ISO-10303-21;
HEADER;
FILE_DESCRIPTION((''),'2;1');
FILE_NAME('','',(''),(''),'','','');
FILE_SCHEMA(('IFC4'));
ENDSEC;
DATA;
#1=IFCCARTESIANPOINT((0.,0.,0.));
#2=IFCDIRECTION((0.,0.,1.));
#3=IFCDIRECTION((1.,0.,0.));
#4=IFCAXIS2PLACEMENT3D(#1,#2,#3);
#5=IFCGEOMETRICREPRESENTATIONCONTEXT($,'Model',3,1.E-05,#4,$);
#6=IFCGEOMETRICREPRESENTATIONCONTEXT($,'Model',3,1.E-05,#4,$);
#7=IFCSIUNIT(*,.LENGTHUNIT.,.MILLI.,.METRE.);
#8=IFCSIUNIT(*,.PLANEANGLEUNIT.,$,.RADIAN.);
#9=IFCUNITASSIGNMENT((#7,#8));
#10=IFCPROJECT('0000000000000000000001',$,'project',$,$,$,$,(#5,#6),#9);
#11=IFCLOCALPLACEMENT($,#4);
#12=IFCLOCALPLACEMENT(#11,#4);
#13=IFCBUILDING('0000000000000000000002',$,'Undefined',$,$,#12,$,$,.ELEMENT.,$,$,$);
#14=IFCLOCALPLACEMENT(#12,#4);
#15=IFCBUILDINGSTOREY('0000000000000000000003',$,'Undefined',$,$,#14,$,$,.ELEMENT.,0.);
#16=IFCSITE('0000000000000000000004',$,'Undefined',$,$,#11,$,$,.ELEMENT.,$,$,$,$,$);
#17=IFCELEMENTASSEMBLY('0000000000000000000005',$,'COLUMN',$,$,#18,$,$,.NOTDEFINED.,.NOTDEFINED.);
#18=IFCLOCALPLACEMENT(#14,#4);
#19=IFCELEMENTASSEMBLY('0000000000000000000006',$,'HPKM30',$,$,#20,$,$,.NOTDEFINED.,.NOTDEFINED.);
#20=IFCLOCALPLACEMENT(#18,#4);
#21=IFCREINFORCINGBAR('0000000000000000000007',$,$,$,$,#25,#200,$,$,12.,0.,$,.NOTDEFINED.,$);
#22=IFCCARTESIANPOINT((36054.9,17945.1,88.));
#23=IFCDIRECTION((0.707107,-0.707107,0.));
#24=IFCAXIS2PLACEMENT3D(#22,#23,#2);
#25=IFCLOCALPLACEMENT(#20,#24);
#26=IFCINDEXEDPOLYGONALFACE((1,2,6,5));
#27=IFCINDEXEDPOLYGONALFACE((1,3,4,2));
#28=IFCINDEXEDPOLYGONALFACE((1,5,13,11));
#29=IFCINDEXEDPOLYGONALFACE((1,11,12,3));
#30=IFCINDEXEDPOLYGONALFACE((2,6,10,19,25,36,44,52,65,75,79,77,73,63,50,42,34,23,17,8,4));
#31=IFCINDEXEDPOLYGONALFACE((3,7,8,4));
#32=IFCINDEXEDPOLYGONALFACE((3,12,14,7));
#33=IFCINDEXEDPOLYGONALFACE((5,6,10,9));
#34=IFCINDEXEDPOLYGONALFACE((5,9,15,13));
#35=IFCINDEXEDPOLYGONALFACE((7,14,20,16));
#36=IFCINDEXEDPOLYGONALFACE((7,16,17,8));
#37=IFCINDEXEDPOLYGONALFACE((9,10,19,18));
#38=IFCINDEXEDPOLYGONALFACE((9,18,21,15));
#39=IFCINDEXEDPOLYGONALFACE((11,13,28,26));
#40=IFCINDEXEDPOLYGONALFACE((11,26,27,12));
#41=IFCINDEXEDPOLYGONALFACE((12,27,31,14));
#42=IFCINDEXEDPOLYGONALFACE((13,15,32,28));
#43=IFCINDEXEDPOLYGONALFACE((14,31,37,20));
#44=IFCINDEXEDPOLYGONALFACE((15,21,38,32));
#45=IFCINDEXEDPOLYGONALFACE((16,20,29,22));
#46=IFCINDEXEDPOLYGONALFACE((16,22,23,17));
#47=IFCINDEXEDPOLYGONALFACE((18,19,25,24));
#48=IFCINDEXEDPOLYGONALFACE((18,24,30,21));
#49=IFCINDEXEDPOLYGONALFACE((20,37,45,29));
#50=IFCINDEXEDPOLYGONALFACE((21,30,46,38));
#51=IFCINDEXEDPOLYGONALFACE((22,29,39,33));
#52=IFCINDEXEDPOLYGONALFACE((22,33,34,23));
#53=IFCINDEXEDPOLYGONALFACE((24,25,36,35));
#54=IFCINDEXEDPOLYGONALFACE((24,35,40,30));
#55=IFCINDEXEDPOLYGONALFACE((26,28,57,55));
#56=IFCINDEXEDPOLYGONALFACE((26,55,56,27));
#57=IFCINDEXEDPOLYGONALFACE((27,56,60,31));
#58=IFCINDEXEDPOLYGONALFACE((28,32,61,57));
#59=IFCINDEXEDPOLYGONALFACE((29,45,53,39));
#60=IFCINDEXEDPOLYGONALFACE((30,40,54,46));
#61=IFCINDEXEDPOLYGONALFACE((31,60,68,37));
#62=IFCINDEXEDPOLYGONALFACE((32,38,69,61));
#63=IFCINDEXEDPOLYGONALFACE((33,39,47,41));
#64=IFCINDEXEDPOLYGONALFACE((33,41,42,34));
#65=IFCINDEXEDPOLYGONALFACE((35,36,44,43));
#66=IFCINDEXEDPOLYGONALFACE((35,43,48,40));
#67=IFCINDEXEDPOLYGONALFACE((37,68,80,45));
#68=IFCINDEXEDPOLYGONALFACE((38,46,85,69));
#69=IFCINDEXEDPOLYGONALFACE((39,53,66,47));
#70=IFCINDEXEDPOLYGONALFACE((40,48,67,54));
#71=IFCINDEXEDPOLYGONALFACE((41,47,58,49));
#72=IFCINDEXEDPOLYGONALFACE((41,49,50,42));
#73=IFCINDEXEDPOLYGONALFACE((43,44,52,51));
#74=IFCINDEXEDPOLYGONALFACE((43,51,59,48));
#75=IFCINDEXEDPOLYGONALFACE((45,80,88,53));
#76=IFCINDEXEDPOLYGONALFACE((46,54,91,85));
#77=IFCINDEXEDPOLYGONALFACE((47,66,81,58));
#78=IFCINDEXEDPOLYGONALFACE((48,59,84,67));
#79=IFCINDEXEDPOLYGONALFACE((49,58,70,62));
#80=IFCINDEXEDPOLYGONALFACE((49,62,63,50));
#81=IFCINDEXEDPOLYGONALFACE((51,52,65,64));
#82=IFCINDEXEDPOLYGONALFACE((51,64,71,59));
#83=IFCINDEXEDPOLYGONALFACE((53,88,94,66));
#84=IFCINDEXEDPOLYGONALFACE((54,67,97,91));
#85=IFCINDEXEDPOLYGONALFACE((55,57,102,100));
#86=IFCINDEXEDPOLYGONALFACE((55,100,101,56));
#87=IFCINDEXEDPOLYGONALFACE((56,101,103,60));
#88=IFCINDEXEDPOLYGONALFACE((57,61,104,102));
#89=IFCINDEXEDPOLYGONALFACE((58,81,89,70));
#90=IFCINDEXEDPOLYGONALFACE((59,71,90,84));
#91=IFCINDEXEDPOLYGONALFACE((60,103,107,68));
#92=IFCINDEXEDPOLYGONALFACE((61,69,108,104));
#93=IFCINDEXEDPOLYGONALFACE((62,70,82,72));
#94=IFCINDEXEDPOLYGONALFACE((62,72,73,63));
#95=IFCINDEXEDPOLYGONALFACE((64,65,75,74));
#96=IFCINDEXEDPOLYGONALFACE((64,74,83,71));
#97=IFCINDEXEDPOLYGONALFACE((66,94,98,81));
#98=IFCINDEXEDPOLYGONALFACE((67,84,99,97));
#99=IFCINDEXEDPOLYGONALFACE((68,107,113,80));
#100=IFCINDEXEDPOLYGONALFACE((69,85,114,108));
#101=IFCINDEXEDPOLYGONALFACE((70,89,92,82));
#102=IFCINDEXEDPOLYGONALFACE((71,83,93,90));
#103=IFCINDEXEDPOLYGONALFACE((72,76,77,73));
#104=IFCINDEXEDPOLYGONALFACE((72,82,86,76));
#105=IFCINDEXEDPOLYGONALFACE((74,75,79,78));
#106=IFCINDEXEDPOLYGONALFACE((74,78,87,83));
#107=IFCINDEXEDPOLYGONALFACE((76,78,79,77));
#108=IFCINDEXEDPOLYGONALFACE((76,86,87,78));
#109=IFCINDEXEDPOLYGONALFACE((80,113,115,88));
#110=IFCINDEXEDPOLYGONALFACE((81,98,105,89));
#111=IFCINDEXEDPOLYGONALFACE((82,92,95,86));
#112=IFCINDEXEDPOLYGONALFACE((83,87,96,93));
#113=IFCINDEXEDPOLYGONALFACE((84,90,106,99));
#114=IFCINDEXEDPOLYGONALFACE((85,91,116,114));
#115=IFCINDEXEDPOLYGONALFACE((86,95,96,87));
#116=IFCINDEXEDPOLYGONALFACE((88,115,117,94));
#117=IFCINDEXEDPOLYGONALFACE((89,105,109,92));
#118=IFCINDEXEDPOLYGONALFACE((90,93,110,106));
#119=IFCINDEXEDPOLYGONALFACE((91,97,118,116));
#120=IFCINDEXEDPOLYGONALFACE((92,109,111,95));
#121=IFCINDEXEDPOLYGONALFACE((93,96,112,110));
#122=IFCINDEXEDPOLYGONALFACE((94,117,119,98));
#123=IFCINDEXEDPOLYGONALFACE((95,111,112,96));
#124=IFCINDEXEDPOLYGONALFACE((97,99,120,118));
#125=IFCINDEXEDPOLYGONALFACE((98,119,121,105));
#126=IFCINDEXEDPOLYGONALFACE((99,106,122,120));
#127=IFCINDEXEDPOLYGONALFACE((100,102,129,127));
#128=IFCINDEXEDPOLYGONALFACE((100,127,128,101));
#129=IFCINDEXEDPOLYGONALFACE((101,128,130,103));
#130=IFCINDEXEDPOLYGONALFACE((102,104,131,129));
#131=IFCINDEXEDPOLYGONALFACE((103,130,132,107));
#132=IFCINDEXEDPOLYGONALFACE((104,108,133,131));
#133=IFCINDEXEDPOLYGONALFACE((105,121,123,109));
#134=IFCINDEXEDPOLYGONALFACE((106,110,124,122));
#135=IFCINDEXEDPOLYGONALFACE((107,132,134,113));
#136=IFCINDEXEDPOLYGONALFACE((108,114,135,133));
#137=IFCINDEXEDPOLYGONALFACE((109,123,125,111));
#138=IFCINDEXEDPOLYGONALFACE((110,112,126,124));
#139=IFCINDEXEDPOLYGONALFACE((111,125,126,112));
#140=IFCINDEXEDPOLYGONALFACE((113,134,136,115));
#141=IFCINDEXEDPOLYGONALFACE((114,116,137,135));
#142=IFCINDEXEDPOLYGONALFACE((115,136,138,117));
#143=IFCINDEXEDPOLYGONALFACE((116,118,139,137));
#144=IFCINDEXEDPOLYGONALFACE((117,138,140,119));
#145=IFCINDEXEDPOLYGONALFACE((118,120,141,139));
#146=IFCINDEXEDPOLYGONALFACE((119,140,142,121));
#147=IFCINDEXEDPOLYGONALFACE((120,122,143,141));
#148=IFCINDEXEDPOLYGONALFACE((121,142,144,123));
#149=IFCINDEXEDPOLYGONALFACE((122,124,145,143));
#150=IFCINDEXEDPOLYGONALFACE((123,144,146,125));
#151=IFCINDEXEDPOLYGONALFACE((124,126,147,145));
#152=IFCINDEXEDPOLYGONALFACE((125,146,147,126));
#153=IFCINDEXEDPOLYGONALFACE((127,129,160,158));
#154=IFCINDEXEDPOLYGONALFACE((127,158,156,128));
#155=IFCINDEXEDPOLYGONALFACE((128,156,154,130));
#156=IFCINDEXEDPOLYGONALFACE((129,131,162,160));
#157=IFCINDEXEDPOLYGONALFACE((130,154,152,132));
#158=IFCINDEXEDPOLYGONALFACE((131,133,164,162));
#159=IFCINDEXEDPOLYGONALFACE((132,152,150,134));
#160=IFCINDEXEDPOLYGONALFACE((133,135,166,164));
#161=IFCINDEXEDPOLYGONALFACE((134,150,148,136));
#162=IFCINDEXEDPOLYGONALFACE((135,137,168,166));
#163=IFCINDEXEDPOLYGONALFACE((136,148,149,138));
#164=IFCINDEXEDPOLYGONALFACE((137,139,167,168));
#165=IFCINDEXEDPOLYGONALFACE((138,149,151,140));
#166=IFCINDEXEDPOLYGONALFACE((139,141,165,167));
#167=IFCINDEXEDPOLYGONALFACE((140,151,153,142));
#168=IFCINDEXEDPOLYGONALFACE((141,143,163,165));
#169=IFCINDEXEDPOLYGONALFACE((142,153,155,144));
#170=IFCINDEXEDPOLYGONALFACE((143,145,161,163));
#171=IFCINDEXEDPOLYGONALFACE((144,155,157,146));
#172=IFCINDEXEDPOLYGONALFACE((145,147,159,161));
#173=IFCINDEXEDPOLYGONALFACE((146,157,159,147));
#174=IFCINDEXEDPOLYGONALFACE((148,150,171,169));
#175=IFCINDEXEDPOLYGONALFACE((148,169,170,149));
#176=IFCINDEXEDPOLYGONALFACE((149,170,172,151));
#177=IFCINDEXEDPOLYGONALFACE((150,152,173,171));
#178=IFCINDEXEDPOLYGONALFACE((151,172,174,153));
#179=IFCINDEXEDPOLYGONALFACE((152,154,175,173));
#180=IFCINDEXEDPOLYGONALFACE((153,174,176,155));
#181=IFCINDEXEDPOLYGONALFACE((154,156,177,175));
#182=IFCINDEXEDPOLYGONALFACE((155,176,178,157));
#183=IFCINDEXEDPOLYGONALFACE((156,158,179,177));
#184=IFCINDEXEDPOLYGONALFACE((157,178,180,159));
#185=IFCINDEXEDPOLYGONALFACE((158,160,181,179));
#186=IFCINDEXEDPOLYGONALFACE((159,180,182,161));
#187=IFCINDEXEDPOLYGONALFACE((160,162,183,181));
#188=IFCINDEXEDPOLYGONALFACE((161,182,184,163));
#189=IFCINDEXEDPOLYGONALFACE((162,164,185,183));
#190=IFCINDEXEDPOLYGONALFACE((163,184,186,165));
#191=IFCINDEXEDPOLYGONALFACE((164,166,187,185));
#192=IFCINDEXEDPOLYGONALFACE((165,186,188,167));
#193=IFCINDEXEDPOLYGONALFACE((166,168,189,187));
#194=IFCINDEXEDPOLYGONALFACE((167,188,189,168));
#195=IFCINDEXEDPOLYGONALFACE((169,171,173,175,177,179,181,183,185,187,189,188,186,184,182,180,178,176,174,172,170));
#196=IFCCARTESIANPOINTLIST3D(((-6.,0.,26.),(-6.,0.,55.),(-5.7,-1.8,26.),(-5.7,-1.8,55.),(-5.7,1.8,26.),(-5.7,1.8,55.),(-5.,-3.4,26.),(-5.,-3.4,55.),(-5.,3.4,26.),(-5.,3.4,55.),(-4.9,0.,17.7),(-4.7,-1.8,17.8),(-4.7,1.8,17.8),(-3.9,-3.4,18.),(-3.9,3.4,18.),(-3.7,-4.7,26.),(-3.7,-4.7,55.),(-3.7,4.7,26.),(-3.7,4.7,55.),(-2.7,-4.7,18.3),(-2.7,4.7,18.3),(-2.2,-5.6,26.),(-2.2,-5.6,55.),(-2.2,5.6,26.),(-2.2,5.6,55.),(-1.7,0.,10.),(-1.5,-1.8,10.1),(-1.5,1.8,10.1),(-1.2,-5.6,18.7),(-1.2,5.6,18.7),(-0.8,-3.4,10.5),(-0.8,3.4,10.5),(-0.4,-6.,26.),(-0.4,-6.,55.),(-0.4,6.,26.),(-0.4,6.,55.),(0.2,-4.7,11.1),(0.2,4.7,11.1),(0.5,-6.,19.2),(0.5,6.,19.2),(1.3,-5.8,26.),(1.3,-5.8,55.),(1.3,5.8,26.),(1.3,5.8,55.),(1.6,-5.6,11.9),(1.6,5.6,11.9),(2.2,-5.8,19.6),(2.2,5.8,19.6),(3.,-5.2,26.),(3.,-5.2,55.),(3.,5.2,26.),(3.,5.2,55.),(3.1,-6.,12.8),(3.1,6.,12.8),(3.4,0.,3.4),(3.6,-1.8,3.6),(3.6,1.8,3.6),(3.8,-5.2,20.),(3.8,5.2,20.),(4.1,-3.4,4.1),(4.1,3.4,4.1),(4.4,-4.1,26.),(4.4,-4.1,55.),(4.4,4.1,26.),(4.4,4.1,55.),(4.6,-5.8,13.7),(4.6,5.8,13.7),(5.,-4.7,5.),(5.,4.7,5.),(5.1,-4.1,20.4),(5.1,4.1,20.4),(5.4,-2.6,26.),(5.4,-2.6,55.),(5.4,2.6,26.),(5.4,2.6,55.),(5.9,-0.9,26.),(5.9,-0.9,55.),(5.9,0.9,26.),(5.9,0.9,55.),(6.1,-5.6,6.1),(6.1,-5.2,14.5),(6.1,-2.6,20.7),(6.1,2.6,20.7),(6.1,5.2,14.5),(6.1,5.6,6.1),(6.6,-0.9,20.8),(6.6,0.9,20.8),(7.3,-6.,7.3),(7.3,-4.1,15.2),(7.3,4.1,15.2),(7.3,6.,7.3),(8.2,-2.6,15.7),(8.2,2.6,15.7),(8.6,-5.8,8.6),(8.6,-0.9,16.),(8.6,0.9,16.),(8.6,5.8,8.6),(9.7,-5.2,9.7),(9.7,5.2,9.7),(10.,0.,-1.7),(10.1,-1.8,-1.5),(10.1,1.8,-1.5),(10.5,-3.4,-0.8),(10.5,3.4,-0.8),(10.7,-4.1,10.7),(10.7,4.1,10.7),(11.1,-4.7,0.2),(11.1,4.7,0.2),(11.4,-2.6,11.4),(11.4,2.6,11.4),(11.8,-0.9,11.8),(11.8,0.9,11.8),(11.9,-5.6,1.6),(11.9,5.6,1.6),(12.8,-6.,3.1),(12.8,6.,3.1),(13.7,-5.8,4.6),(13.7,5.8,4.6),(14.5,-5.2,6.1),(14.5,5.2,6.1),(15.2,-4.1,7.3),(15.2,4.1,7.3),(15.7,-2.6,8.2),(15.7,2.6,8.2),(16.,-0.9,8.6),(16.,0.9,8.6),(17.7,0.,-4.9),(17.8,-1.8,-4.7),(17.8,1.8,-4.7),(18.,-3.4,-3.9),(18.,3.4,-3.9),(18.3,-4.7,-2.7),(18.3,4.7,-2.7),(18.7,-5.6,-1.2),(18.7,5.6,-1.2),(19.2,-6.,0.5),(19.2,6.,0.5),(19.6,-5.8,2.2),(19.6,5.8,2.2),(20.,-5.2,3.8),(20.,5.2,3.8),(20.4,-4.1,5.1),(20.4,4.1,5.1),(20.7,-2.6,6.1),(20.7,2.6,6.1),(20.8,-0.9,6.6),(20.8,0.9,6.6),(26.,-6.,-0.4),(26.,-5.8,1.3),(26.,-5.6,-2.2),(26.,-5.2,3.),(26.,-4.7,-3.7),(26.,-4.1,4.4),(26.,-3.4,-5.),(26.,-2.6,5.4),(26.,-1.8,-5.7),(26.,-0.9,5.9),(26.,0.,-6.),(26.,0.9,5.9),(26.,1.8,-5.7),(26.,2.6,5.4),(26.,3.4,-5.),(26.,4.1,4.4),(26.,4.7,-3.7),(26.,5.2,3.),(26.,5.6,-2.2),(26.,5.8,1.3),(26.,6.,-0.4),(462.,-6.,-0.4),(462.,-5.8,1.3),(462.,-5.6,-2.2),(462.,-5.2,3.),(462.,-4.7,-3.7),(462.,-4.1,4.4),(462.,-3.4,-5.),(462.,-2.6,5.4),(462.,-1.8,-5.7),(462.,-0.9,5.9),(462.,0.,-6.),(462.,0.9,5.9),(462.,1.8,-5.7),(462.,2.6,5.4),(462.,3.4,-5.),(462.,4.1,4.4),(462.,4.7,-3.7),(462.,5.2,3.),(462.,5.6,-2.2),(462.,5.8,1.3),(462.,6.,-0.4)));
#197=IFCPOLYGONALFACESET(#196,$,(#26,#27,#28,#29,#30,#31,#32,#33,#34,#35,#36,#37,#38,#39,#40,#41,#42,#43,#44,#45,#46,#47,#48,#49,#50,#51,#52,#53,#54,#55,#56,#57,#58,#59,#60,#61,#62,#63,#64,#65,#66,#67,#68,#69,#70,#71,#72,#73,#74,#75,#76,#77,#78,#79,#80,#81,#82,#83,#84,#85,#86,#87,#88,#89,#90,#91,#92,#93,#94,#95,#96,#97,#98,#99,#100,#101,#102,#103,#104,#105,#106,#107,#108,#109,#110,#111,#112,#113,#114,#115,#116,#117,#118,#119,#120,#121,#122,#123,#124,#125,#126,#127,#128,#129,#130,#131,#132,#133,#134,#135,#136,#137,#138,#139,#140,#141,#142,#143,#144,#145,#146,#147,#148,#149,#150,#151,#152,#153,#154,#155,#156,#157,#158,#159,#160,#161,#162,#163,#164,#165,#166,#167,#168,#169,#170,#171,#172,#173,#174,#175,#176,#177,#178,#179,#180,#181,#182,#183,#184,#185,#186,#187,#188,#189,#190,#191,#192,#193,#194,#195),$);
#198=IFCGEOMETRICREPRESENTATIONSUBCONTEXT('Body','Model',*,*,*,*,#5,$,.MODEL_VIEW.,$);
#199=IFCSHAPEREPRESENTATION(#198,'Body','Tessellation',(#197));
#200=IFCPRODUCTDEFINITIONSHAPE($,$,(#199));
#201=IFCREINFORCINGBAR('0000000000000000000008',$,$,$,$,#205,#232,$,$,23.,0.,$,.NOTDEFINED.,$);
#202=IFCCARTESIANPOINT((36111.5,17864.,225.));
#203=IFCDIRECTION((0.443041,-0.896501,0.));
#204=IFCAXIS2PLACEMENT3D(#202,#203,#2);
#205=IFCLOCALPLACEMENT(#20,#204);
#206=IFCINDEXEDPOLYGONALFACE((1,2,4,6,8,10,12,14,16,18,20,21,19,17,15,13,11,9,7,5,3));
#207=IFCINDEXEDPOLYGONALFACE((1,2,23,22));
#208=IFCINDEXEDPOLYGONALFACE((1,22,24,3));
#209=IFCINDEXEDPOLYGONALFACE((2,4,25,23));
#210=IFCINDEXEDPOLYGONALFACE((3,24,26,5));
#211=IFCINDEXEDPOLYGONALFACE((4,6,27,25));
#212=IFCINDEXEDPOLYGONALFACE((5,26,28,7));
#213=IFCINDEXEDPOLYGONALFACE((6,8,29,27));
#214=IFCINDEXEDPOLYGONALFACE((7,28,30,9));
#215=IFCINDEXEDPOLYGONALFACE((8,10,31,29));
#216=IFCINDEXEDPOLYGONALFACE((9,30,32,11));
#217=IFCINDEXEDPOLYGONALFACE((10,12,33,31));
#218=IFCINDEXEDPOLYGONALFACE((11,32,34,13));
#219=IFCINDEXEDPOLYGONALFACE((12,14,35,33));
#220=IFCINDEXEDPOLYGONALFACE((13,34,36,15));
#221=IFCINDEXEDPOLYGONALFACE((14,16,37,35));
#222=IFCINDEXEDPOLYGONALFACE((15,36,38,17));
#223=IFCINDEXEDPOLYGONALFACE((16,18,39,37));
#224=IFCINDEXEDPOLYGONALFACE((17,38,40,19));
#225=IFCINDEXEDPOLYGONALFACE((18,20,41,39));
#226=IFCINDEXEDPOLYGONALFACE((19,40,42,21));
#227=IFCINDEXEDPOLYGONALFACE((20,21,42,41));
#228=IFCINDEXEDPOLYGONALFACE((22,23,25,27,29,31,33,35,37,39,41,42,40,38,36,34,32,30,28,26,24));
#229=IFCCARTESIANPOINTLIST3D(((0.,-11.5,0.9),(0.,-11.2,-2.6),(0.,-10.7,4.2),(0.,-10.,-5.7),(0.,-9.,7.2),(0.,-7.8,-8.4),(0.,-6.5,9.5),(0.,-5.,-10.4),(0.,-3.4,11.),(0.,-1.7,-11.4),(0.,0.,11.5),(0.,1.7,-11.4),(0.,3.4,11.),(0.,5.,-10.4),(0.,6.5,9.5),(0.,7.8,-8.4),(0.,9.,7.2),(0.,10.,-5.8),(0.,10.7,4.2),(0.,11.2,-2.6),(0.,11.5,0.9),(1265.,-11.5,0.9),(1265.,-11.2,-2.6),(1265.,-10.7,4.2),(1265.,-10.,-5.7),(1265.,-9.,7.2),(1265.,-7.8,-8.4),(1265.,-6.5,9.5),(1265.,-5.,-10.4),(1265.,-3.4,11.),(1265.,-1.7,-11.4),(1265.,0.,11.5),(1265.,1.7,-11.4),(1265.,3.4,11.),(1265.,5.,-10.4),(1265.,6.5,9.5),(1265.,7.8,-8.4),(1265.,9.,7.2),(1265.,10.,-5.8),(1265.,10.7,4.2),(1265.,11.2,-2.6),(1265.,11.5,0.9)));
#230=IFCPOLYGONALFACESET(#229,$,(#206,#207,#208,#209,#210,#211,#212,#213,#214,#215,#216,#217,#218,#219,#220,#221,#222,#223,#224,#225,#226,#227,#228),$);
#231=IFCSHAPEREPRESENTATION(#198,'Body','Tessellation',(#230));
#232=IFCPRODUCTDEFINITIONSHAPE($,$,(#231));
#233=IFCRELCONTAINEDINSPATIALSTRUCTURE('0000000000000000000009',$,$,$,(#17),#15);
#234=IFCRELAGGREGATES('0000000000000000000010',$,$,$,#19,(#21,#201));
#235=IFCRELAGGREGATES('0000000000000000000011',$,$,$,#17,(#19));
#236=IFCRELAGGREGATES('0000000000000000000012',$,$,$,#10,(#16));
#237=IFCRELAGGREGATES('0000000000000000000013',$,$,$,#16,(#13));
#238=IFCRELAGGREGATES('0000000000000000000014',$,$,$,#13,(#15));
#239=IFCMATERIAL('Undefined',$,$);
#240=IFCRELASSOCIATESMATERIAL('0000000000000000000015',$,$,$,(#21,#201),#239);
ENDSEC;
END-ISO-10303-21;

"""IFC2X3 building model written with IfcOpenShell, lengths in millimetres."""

from ifc_helpers import new_model, entity, si_unit, frame, origin_with_axes, place, context, subcontext, project, spatial, source, transform, mapped, material, element, aggregate, save


model = new_model("IFC2X3")

# Units and contexts
model_context_1 = context("Model", 3, precision=1e-05, world=origin_with_axes())
model_context_2 = context("Model", 3, precision=1e-05, world=origin_with_axes())
body_context = subcontext(model_context_1, "Body", "Model", "MODEL_VIEW")
ifc_project = project(units=[si_unit("LENGTHUNIT", "METRE", prefix="MILLI"), si_unit("PLANEANGLEUNIT", "RADIAN")], contexts=[model_context_1, model_context_2])

# Site, building, storey
site_placement = place(None, origin_with_axes())
site = spatial("IfcSite", under=ifc_project, at=site_placement, Name="Undefined", CompositionType="ELEMENT")
building_placement = place(site_placement, origin_with_axes())
building = spatial("IfcBuilding", under=site, at=building_placement, Name="Undefined", CompositionType="ELEMENT")
storey_placement = place(building_placement, origin_with_axes())
storey = spatial("IfcBuildingStorey", under=building, at=storey_placement, Name="Undefined", CompositionType="ELEMENT", Elevation=0.0)

# Element assembly
assembly_1_placement = place(storey_placement, origin_with_axes())
assembly_1 = element("IfcElementAssembly", 1, at=assembly_1_placement, inside=storey, Name="COLUMN", AssemblyPlace="NOTDEFINED", PredefinedType="NOTDEFINED")

# Element assembly
assembly_2_placement = place(assembly_1_placement, origin_with_axes())
assembly_2 = element("IfcElementAssembly", 2, at=assembly_2_placement, Name="HPKM30", AssemblyPlace="NOTDEFINED", PredefinedType="NOTDEFINED")

# Shared definitions
ifc_material_1 = material(Name="Undefined")

# Reinforcing bars
shared_shape_1 = source(origin_with_axes(), body_context, "Body", "AdvancedSweptSolid", [
    entity("IfcSweptDiskSolid", entity("IfcCompositeCurve", [entity("IfcCompositeCurveSegment", "CONTINUOUS", True, entity("IfcTrimmedCurve", entity("IfcLine", entity("IfcCartesianPoint", [0.0, 0.0, 0.0]), entity("IfcVector", entity("IfcDirection", [0.0, 0.0, -1.0]), 1.0)), [entity("IfcParameterValue", 0.0)], [entity("IfcParameterValue", 29.0)], True, "PARAMETER")), entity("IfcCompositeCurveSegment", "CONTINUOUS", True, entity("IfcTrimmedCurve", entity("IfcCircle", entity("IfcAxis2Placement3D", entity("IfcCartesianPoint", [26.0, 0.0, -29.0]), entity("IfcDirection", [0.0, -1.0, 0.0]), entity("IfcDirection", [-1.0, 0.0, 0.0])), 26.0), [entity("IfcParameterValue", 0.0)], [entity("IfcParameterValue", 1.570796)], True, "PARAMETER")), entity("IfcCompositeCurveSegment", "DISCONTINUOUS", True, entity("IfcTrimmedCurve", entity("IfcLine", entity("IfcCartesianPoint", [26.0, 0.0, -55.0]), entity("IfcVector", entity("IfcDirection", [1.0, 0.0, 0.0]), 1.0)), [entity("IfcParameterValue", 0.0)], [entity("IfcParameterValue", 436.0)], True, "PARAMETER"))], False), 6.0, None, 0.0, 466.6),
])
reinforcing_bar_1_placement = place(assembly_2_placement, frame((36054.9, 17945.1, 88.0), z_axis=(0.707107, -0.707107, 0.0), x_axis=(0.0, 0.0, 1.0)))
reinforcing_bar_1 = element("IfcReinforcingBar", 3, at=reinforcing_bar_1_placement, material=ifc_material_1, BarRole="NOTDEFINED", CrossSectionArea=0.0, NominalDiameter=12.0, context=body_context, shape_type="MappedRepresentation", body=[
    mapped(shared_shape_1, transform((0.0, 0.0, 55.0))),
])
shared_shape_2 = source(origin_with_axes(), body_context, "Body", "AdvancedSweptSolid", [
    entity("IfcSweptDiskSolid", entity("IfcTrimmedCurve", entity("IfcLine", entity("IfcCartesianPoint", [0.0, 0.0, 0.0]), entity("IfcVector", entity("IfcDirection", [1.0, 0.0, 0.0]), 1.0)), [entity("IfcParameterValue", 0.0)], [entity("IfcParameterValue", 1265.0)], True, "PARAMETER"), 11.5, None, 0.0, 1265.0),
])
reinforcing_bar_2_placement = place(assembly_2_placement, frame((36111.5, 17864.0, 225.0), z_axis=(0.443041, -0.896501, 0.0), x_axis=(0.0, 0.0, 1.0)))
reinforcing_bar_2 = element("IfcReinforcingBar", 4, at=reinforcing_bar_2_placement, material=ifc_material_1, BarRole="NOTDEFINED", CrossSectionArea=0.0, NominalDiameter=23.0, context=body_context, shape_type="MappedRepresentation", body=[
    mapped(shared_shape_2, transform((0.0, 0.0, 0.0))),
])
aggregate(assembly_2, [reinforcing_bar_1, reinforcing_bar_2])
aggregate(assembly_1, [assembly_2])

save(model, "model.ifc")
